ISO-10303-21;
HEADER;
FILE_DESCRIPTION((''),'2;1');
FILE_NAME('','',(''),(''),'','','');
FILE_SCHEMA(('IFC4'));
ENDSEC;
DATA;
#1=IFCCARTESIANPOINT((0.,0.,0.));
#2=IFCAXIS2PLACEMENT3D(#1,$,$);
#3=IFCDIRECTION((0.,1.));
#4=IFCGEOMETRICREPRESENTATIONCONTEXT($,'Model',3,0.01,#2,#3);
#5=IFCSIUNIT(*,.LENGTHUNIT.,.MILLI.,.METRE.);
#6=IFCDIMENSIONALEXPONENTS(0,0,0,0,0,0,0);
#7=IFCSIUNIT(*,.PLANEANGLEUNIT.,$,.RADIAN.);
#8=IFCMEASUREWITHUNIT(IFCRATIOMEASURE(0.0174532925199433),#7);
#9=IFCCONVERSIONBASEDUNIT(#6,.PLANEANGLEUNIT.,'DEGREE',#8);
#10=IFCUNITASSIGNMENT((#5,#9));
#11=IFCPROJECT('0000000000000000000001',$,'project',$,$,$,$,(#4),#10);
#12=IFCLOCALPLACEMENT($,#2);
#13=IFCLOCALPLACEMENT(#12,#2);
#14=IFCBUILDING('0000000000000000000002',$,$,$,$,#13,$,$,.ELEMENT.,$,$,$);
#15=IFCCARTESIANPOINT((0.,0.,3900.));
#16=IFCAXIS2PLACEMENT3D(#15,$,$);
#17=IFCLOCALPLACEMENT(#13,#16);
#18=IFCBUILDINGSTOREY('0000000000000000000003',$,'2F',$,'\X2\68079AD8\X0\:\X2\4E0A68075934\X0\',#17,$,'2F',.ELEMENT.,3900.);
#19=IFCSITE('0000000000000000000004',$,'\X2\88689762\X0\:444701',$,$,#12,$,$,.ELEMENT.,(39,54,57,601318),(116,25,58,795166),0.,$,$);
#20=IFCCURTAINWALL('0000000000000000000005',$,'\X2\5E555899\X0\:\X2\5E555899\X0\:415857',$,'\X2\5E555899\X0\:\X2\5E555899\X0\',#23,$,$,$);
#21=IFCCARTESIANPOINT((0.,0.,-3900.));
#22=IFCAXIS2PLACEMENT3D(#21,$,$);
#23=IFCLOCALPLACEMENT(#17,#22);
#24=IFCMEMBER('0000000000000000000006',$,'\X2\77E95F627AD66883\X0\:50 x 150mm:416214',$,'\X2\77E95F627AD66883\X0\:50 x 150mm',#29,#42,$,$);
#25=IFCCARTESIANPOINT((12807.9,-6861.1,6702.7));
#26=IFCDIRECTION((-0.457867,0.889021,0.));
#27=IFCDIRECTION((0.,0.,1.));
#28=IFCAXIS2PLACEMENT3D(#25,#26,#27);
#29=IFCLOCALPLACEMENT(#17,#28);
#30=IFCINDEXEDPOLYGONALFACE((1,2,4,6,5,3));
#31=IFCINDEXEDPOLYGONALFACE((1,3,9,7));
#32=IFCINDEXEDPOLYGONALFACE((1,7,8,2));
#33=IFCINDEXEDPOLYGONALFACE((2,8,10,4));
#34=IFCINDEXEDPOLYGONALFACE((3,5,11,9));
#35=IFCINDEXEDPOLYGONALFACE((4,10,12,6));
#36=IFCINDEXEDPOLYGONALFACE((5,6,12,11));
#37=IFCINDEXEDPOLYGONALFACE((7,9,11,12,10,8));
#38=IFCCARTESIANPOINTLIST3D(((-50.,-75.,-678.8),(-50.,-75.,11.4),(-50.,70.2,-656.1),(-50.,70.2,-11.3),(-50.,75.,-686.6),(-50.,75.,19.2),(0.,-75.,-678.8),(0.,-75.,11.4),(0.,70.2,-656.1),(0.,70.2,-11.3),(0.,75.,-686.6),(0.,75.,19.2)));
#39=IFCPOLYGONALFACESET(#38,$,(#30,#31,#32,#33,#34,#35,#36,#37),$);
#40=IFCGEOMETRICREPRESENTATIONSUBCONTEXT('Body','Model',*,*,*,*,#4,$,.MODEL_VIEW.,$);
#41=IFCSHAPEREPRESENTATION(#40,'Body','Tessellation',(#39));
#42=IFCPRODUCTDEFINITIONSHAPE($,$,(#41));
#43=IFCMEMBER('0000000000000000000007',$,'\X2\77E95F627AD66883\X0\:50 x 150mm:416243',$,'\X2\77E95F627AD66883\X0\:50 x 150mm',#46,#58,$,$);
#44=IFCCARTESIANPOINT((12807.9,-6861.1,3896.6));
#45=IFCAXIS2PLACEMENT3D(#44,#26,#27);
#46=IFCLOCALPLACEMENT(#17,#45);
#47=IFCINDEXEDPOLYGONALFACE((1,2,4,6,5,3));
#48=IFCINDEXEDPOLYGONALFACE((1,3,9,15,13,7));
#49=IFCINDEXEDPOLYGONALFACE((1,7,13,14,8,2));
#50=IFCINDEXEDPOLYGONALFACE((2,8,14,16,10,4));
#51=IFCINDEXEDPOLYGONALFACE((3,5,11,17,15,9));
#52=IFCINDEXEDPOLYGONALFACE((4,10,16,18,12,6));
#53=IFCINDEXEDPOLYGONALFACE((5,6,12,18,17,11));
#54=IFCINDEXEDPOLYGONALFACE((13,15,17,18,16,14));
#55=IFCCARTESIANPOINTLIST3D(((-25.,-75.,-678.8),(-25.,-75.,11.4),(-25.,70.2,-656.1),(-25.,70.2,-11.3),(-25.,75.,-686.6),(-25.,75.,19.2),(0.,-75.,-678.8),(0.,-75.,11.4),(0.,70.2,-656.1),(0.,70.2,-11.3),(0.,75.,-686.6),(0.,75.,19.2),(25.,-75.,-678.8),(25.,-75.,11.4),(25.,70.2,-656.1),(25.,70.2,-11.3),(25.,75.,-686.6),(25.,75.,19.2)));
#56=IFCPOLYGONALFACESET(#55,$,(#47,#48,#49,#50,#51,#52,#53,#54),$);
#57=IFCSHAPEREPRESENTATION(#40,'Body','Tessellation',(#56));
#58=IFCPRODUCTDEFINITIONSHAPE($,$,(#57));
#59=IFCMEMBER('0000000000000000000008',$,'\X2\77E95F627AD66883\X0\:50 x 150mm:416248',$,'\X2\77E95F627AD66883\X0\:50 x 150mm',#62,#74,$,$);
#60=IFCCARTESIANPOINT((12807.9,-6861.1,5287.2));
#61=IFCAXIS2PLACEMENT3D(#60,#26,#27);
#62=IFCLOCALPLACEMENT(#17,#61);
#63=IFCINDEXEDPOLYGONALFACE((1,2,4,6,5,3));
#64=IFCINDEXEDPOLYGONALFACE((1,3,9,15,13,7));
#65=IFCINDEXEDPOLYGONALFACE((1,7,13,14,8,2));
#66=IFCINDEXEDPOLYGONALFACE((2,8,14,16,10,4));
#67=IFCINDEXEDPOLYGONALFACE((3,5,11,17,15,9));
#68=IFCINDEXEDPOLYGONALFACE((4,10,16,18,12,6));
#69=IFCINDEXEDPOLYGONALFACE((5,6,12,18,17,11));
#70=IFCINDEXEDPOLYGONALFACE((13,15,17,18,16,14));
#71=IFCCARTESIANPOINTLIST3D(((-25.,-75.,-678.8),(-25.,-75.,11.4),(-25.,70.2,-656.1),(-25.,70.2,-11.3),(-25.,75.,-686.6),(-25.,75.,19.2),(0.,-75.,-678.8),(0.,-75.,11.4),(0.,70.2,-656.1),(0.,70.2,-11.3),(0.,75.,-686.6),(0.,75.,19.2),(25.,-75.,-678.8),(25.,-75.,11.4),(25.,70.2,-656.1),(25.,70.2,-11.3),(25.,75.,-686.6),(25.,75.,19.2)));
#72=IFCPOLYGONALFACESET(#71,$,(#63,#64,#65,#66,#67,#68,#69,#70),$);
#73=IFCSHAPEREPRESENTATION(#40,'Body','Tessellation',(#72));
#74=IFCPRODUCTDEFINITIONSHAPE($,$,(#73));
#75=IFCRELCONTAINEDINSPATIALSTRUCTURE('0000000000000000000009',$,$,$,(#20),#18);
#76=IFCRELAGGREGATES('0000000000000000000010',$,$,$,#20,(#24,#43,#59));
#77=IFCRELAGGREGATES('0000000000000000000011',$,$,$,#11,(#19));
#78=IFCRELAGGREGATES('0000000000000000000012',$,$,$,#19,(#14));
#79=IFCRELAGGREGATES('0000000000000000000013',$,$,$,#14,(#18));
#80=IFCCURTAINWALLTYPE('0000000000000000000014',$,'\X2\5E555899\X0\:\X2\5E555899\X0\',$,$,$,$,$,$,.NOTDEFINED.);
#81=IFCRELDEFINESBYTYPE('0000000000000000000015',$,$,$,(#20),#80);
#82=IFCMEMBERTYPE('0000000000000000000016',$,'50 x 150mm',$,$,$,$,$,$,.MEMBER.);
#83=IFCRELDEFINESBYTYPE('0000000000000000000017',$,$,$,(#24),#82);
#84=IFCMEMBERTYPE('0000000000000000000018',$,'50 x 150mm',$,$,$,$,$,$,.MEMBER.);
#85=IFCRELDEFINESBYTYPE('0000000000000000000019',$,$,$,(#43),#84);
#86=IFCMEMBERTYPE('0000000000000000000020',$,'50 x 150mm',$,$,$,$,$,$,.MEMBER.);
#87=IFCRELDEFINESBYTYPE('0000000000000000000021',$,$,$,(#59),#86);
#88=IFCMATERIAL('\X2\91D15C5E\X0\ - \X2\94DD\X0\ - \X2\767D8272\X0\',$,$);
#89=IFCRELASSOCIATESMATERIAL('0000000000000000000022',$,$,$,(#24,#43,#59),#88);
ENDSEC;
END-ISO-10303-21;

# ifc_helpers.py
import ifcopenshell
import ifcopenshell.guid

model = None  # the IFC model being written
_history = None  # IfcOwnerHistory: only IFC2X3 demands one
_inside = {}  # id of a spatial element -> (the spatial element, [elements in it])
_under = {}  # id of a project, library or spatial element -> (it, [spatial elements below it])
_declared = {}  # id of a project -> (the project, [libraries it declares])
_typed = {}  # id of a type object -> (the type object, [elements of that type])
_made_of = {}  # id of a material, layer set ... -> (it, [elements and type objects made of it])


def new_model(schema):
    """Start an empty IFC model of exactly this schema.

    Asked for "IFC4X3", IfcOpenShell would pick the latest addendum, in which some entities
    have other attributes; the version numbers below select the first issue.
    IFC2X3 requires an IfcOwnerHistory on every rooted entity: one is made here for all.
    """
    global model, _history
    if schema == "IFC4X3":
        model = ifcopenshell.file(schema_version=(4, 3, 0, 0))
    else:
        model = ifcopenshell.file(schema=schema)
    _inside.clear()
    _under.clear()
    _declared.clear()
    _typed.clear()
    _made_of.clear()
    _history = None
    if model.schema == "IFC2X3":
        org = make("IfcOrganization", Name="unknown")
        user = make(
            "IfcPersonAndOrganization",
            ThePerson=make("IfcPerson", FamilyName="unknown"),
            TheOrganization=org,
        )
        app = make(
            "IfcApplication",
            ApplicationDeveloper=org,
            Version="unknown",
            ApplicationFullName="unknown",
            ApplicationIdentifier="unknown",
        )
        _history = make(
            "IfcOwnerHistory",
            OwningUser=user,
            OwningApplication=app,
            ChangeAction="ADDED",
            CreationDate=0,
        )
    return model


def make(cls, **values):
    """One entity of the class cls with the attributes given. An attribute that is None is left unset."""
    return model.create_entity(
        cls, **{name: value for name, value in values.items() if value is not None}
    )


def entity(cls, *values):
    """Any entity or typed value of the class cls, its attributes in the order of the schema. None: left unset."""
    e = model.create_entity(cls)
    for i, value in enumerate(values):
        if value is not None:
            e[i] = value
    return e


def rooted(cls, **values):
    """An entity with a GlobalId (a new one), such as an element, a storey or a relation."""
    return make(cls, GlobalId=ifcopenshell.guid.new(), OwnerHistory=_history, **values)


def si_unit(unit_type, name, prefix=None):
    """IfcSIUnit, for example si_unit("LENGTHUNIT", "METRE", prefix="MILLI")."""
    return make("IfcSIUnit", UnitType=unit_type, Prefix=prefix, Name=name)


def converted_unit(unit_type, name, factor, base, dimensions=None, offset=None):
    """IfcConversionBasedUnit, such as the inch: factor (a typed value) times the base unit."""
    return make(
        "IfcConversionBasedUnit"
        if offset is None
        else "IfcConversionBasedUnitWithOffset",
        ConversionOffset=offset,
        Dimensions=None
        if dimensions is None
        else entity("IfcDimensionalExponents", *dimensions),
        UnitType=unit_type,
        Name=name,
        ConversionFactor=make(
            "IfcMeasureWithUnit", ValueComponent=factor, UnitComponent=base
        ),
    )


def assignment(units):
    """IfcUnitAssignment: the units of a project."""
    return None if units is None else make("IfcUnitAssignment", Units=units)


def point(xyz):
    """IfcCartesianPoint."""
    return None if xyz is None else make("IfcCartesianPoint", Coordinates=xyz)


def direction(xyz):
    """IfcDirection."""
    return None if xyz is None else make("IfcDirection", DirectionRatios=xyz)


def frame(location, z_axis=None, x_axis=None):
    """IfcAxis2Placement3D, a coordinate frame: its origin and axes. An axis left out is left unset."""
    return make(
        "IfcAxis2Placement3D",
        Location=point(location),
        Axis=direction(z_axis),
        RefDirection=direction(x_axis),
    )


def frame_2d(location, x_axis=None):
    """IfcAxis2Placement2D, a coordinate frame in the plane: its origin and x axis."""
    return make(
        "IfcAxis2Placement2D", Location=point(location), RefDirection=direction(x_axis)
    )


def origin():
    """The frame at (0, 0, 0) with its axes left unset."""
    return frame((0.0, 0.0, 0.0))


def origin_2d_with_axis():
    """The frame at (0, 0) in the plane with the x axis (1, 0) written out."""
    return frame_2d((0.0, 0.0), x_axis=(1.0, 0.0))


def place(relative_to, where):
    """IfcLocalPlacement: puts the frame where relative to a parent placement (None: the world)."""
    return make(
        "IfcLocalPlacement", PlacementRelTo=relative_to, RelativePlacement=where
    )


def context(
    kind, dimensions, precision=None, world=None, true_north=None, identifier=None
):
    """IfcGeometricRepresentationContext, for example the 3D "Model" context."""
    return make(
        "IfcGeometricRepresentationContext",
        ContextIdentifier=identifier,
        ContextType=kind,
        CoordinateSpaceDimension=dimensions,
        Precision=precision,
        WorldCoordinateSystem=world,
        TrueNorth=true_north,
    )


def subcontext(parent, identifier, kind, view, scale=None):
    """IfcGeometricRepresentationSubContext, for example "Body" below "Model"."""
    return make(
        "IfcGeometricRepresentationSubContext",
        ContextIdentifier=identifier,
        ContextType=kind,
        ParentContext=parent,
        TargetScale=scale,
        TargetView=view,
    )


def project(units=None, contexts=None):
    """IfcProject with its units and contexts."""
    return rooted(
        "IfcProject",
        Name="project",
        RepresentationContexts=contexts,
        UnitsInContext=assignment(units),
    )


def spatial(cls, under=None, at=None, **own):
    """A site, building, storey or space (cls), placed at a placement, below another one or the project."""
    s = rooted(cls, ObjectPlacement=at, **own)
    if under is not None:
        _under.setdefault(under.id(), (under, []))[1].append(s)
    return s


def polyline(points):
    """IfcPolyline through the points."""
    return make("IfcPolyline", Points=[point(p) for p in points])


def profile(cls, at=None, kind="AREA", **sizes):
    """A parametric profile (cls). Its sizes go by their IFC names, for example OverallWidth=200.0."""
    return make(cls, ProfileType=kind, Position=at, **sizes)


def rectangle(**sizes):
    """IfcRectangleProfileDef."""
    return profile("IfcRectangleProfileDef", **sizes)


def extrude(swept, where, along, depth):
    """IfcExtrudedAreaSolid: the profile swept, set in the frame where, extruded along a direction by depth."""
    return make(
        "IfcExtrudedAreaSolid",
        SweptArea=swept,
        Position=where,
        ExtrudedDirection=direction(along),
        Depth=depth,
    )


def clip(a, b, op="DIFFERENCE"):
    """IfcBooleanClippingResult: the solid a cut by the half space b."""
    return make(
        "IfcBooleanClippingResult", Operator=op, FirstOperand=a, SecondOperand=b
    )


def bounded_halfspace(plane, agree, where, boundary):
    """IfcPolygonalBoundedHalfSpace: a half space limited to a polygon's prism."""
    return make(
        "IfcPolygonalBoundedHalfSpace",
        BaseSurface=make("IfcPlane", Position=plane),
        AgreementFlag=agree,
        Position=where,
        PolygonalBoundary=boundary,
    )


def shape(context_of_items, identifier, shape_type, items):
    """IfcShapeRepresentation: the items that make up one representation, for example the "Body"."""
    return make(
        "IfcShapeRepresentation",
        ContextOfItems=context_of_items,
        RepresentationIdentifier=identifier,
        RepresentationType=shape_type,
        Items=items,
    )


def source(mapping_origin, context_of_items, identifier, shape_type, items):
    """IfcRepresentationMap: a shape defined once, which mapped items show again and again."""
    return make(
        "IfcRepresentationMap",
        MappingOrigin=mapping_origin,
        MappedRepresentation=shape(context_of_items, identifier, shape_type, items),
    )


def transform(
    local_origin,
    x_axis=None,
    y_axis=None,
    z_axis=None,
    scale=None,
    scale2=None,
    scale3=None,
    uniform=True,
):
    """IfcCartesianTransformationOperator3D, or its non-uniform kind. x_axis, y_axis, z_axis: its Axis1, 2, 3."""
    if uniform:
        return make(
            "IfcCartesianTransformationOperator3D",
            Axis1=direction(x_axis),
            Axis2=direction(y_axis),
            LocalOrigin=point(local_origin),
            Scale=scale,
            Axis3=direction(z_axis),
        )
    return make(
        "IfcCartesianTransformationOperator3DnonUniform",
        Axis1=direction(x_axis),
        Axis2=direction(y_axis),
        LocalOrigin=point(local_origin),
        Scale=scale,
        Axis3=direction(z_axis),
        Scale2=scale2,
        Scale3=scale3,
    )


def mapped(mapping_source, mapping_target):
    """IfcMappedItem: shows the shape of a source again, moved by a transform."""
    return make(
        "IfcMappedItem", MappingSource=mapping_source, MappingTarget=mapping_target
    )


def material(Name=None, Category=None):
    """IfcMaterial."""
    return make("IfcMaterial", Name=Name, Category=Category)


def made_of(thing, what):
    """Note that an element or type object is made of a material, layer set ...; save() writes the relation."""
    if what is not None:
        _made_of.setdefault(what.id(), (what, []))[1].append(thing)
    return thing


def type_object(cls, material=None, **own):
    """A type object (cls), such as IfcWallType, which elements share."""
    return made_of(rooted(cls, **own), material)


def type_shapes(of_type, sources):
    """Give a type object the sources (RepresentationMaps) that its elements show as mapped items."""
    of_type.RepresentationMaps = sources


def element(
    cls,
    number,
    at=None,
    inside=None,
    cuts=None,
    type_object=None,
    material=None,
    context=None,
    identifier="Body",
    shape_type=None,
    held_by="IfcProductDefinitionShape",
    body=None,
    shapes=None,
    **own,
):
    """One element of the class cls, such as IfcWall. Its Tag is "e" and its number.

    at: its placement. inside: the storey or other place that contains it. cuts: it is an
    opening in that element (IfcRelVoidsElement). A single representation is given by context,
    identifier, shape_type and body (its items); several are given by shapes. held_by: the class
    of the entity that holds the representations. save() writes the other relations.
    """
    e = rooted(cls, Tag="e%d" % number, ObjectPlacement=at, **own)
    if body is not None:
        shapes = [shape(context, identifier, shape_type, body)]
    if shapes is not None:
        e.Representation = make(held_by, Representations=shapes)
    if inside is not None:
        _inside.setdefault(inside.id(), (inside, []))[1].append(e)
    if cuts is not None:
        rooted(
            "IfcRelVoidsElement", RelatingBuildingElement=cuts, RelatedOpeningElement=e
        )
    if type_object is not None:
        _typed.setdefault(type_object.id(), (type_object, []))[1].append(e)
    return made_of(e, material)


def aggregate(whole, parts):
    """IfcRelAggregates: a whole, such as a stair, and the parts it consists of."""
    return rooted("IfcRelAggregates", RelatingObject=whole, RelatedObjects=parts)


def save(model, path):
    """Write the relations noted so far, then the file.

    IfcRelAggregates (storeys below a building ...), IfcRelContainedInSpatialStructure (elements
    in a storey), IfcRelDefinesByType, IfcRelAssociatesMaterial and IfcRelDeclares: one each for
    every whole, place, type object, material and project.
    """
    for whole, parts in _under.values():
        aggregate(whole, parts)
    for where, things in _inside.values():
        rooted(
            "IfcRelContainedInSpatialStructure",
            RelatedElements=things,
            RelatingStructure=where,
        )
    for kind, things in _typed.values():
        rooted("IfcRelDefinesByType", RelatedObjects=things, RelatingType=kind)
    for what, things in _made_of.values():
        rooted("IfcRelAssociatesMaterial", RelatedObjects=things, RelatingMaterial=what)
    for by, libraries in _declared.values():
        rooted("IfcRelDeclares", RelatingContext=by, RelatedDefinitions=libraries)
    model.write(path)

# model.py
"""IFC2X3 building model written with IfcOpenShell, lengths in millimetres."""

from ifc_helpers import new_model, entity, si_unit, converted_unit, direction, frame, origin, origin_2d_with_axis, place, context, subcontext, project, spatial, polyline, rectangle, extrude, clip, bounded_halfspace, source, transform, mapped, material, type_object, type_shapes, element, aggregate, save


model = new_model("IFC2X3")

# Units and contexts
model_context = context("Model", 3, precision=0.01, world=origin(), true_north=direction((0.0, 1.0)))
body_context = subcontext(model_context, "Body", "Model", "MODEL_VIEW")
ifc_project = project(units=[si_unit("LENGTHUNIT", "METRE", prefix="MILLI"), converted_unit("PLANEANGLEUNIT", "DEGREE", entity("IfcRatioMeasure", 0.0174532925199433), si_unit("PLANEANGLEUNIT", "RADIAN"), dimensions=[0, 0, 0, 0, 0, 0, 0])], contexts=[model_context])

# Site, building, storey
site_placement = place(None, origin())
site = spatial("IfcSite", under=ifc_project, at=site_placement, Name="表面:444701", CompositionType="ELEMENT", RefLatitude=(39, 54, 57, 601318), RefLongitude=(116, 25, 58, 795166), RefElevation=0.0)
building_placement = place(site_placement, origin())
building = spatial("IfcBuilding", under=site, at=building_placement, CompositionType="ELEMENT")
storey_placement = place(building_placement, frame((0.0, 0.0, 3900.0)))
storey = spatial("IfcBuildingStorey", under=building, at=storey_placement, Name="2F", ObjectType="标高:上标头", LongName="2F", CompositionType="ELEMENT", Elevation=3900.0)

# Curtain wall, member
curtain_wall_type = type_object("IfcCurtainWallType", Name="幕墙:幕墙", PredefinedType="NOTDEFINED")
curtain_wall_1_placement = place(storey_placement, frame((0.0, 0.0, -3900.0)))
curtain_wall_1 = element("IfcCurtainWall", 1, at=curtain_wall_1_placement, inside=storey, type_object=curtain_wall_type, Name="幕墙:幕墙:415857", ObjectType="幕墙:幕墙")
ifc_material_1 = material(Name="金属 - 铝 - 白色")
member_type_1 = type_object("IfcMemberType", Name="50 x 150mm", PredefinedType="MEMBER")
shared_shape_1 = source(origin(), body_context, "Body", "Clipping", [
    clip(clip(clip(clip(extrude(rectangle(XDim=50.0, YDim=150.0, at=origin_2d_with_axis()), frame((-25.0, 0.0, -686.6)), (0.0, 0.0, 1.0), 705.8), bounded_halfspace(frame((-1415.5, -78.0, -679.3), z_axis=(0.0, 0.154283, -0.988027), x_axis=(1.0, 0.0, 0.0)), False, frame((-25.0, 0.0, -686.6)), polyline([(25.0, 70.2), (25.0, -75.0), (-25.0, -75.0), (-25.0, 70.2), (25.0, 70.2)]))), bounded_halfspace(frame((-1415.5, 70.2, -656.1), z_axis=(0.0, -0.988027, -0.154283), x_axis=(1.0, 0.0, 0.0)), False, frame((-25.0, 0.0, -686.6)), polyline([(25.0, 75.0), (25.0, 70.2), (-25.0, 70.2), (-25.0, 75.0), (25.0, 75.0)]))), bounded_halfspace(frame((-1415.5, 78.0, 38.1), z_axis=(0.0, -0.988027, 0.154283), x_axis=(1.0, 0.0, 0.0)), False, frame((-25.0, 0.0, -686.6)), polyline([(25.0, 75.0), (-25.0, 75.0), (-25.0, 70.2), (25.0, 70.2), (25.0, 75.0)]))), bounded_halfspace(frame((-1415.5, 70.2, -11.3), z_axis=(0.0, 0.154283, 0.988027), x_axis=(1.0, 0.0, 0.0)), False, frame((-25.0, 0.0, -686.6)), polyline([(-25.0, 70.2), (-25.0, -75.0), (25.0, -75.0), (25.0, 70.2), (-25.0, 70.2)]))),
])
type_shapes(member_type_1, [shared_shape_1])
member_1_placement = place(storey_placement, frame((12807.9, -6861.1, 6702.7), z_axis=(-0.457867, 0.889021, 0.0), x_axis=(0.0, 0.0, 1.0)))
member_1 = element("IfcMember", 2, at=member_1_placement, type_object=member_type_1, material=ifc_material_1, Name="矩形竖梃:50 x 150mm:416214", ObjectType="矩形竖梃:50 x 150mm", context=body_context, shape_type="MappedRepresentation", body=[
    mapped(shared_shape_1, transform((0.0, 0.0, 0.0), scale=1.0)),
])

# Members
member_type_2 = type_object("IfcMemberType", Name="50 x 150mm", PredefinedType="MEMBER")
shared_shape_2 = source(origin(), body_context, "Body", "Clipping", [
    clip(clip(clip(clip(clip(clip(clip(clip(extrude(rectangle(XDim=150.0, YDim=50.0, at=origin_2d_with_axis()), frame((0.0, 0.0, -686.6), z_axis=(0.0, 0.0, 1.0), x_axis=(0.0, -1.0, 0.0)), (0.0, 0.0, 1.0), 705.8), bounded_halfspace(frame((-1390.5, -78.0, -679.3), z_axis=(0.0, 0.154283, -0.988027), x_axis=(1.0, 0.0, 0.0)), False, frame((0.0, 0.0, -686.6), z_axis=(0.0, 0.0, 1.0), x_axis=(0.0, -1.0, 0.0)), polyline([(75.0, 0.0), (75.0, -25.0), (-70.2, -25.0), (-70.2, 0.0), (75.0, 0.0)]))), bounded_halfspace(frame((0.0, -78.0, -679.3), z_axis=(0.0, 0.154283, -0.988027), x_axis=(1.0, 0.0, 0.0)), False, frame((0.0, 0.0, -686.6), z_axis=(0.0, 0.0, 1.0), x_axis=(0.0, -1.0, 0.0)), polyline([(-70.2, 25.0), (75.0, 25.0), (75.0, 0.0), (-70.2, 0.0), (-70.2, 25.0)]))), bounded_halfspace(frame((-1390.5, 70.2, -656.1), z_axis=(0.0, -0.988027, -0.154283), x_axis=(1.0, 0.0, 0.0)), False, frame((0.0, 0.0, -686.6), z_axis=(0.0, 0.0, 1.0), x_axis=(0.0, -1.0, 0.0)), polyline([(-70.2, -25.0), (-75.0, -25.0), (-75.0, 0.0), (-70.2, 0.0), (-70.2, -25.0)]))), bounded_halfspace(frame((0.0, 70.2, -656.1), z_axis=(0.0, -0.988027, -0.154283), x_axis=(1.0, 0.0, 0.0)), False, frame((0.0, 0.0, -686.6), z_axis=(0.0, 0.0, 1.0), x_axis=(0.0, -1.0, 0.0)), polyline([(-75.0, 25.0), (-70.2, 25.0), (-70.2, 0.0), (-75.0, 0.0), (-75.0, 25.0)]))), bounded_halfspace(frame((-1390.5, 78.0, 38.1), z_axis=(0.0, -0.988027, 0.154283), x_axis=(1.0, 0.0, 0.0)), False, frame((0.0, 0.0, -686.6), z_axis=(0.0, 0.0, 1.0), x_axis=(0.0, -1.0, 0.0)), polyline([(-75.0, 0.0), (-75.0, -25.0), (-70.2, -25.0), (-70.2, 0.0), (-75.0, 0.0)]))), bounded_halfspace(frame((0.0, 78.0, 38.1), z_axis=(0.0, -0.988027, 0.154283), x_axis=(1.0, 0.0, 0.0)), False, frame((0.0, 0.0, -686.6), z_axis=(0.0, 0.0, 1.0), x_axis=(0.0, -1.0, 0.0)), polyline([(-75.0, 25.0), (-75.0, 0.0), (-70.2, 0.0), (-70.2, 25.0), (-75.0, 25.0)]))), bounded_halfspace(frame((-1390.5, 70.2, -11.3), z_axis=(0.0, 0.154283, 0.988027), x_axis=(1.0, 0.0, 0.0)), False, frame((0.0, 0.0, -686.6), z_axis=(0.0, 0.0, 1.0), x_axis=(0.0, -1.0, 0.0)), polyline([(-70.2, -25.0), (75.0, -25.0), (75.0, 0.0), (-70.2, 0.0), (-70.2, -25.0)]))), bounded_halfspace(frame((0.0, 70.2, -11.3), z_axis=(0.0, 0.154283, 0.988027), x_axis=(1.0, 0.0, 0.0)), False, frame((0.0, 0.0, -686.6), z_axis=(0.0, 0.0, 1.0), x_axis=(0.0, -1.0, 0.0)), polyline([(75.0, 0.0), (75.0, 25.0), (-70.2, 25.0), (-70.2, 0.0), (75.0, 0.0)]))),
])
type_shapes(member_type_2, [shared_shape_2])
member_2_placement = place(storey_placement, frame((12807.9, -6861.1, 3896.6), z_axis=(-0.457867, 0.889021, 0.0), x_axis=(0.0, 0.0, 1.0)))
member_2 = element("IfcMember", 3, at=member_2_placement, type_object=member_type_2, material=ifc_material_1, Name="矩形竖梃:50 x 150mm:416243", ObjectType="矩形竖梃:50 x 150mm", context=body_context, shape_type="MappedRepresentation", body=[
    mapped(shared_shape_2, transform((0.0, 0.0, 0.0), scale=1.0)),
])
member_type_3 = type_object("IfcMemberType", Name="50 x 150mm", PredefinedType="MEMBER")
shared_shape_3 = source(origin(), body_context, "Body", "Clipping", [
    clip(clip(clip(clip(clip(clip(clip(clip(extrude(rectangle(XDim=150.0, YDim=50.0, at=origin_2d_with_axis()), frame((0.0, 0.0, -686.6), z_axis=(0.0, 0.0, 1.0), x_axis=(0.0, -1.0, 0.0)), (0.0, 0.0, 1.0), 705.8), bounded_halfspace(frame((-1390.5, -78.0, -679.3), z_axis=(0.0, 0.154283, -0.988027), x_axis=(1.0, 0.0, 0.0)), False, frame((0.0, 0.0, -686.6), z_axis=(0.0, 0.0, 1.0), x_axis=(0.0, -1.0, 0.0)), polyline([(75.0, 0.0), (75.0, -25.0), (-70.2, -25.0), (-70.2, 0.0), (75.0, 0.0)]))), bounded_halfspace(frame((0.0, -78.0, -679.3), z_axis=(0.0, 0.154283, -0.988027), x_axis=(1.0, 0.0, 0.0)), False, frame((0.0, 0.0, -686.6), z_axis=(0.0, 0.0, 1.0), x_axis=(0.0, -1.0, 0.0)), polyline([(-70.2, 25.0), (75.0, 25.0), (75.0, 0.0), (-70.2, 0.0), (-70.2, 25.0)]))), bounded_halfspace(frame((-1390.5, 70.2, -656.1), z_axis=(0.0, -0.988027, -0.154283), x_axis=(1.0, 0.0, 0.0)), False, frame((0.0, 0.0, -686.6), z_axis=(0.0, 0.0, 1.0), x_axis=(0.0, -1.0, 0.0)), polyline([(-70.2, -25.0), (-75.0, -25.0), (-75.0, 0.0), (-70.2, 0.0), (-70.2, -25.0)]))), bounded_halfspace(frame((0.0, 70.2, -656.1), z_axis=(0.0, -0.988027, -0.154283), x_axis=(1.0, 0.0, 0.0)), False, frame((0.0, 0.0, -686.6), z_axis=(0.0, 0.0, 1.0), x_axis=(0.0, -1.0, 0.0)), polyline([(-75.0, 25.0), (-70.2, 25.0), (-70.2, 0.0), (-75.0, 0.0), (-75.0, 25.0)]))), bounded_halfspace(frame((-1390.5, 78.0, 38.1), z_axis=(0.0, -0.988027, 0.154283), x_axis=(1.0, 0.0, 0.0)), False, frame((0.0, 0.0, -686.6), z_axis=(0.0, 0.0, 1.0), x_axis=(0.0, -1.0, 0.0)), polyline([(-75.0, 0.0), (-75.0, -25.0), (-70.2, -25.0), (-70.2, 0.0), (-75.0, 0.0)]))), bounded_halfspace(frame((0.0, 78.0, 38.1), z_axis=(0.0, -0.988027, 0.154283), x_axis=(1.0, 0.0, 0.0)), False, frame((0.0, 0.0, -686.6), z_axis=(0.0, 0.0, 1.0), x_axis=(0.0, -1.0, 0.0)), polyline([(-75.0, 25.0), (-75.0, 0.0), (-70.2, 0.0), (-70.2, 25.0), (-75.0, 25.0)]))), bounded_halfspace(frame((-1390.5, 70.2, -11.3), z_axis=(0.0, 0.154283, 0.988027), x_axis=(1.0, 0.0, 0.0)), False, frame((0.0, 0.0, -686.6), z_axis=(0.0, 0.0, 1.0), x_axis=(0.0, -1.0, 0.0)), polyline([(-70.2, -25.0), (75.0, -25.0), (75.0, 0.0), (-70.2, 0.0), (-70.2, -25.0)]))), bounded_halfspace(frame((0.0, 70.2, -11.3), z_axis=(0.0, 0.154283, 0.988027), x_axis=(1.0, 0.0, 0.0)), False, frame((0.0, 0.0, -686.6), z_axis=(0.0, 0.0, 1.0), x_axis=(0.0, -1.0, 0.0)), polyline([(75.0, 0.0), (75.0, 25.0), (-70.2, 25.0), (-70.2, 0.0), (75.0, 0.0)]))),
])
type_shapes(member_type_3, [shared_shape_3])
member_3_placement = place(storey_placement, frame((12807.9, -6861.1, 5287.2), z_axis=(-0.457867, 0.889021, 0.0), x_axis=(0.0, 0.0, 1.0)))
member_3 = element("IfcMember", 4, at=member_3_placement, type_object=member_type_3, material=ifc_material_1, Name="矩形竖梃:50 x 150mm:416248", ObjectType="矩形竖梃:50 x 150mm", context=body_context, shape_type="MappedRepresentation", body=[
    mapped(shared_shape_3, transform((0.0, 0.0, 0.0), scale=1.0)),
])

aggregate(curtain_wall_1, [member_1, member_2, member_3])

save(model, "model.ifc")
